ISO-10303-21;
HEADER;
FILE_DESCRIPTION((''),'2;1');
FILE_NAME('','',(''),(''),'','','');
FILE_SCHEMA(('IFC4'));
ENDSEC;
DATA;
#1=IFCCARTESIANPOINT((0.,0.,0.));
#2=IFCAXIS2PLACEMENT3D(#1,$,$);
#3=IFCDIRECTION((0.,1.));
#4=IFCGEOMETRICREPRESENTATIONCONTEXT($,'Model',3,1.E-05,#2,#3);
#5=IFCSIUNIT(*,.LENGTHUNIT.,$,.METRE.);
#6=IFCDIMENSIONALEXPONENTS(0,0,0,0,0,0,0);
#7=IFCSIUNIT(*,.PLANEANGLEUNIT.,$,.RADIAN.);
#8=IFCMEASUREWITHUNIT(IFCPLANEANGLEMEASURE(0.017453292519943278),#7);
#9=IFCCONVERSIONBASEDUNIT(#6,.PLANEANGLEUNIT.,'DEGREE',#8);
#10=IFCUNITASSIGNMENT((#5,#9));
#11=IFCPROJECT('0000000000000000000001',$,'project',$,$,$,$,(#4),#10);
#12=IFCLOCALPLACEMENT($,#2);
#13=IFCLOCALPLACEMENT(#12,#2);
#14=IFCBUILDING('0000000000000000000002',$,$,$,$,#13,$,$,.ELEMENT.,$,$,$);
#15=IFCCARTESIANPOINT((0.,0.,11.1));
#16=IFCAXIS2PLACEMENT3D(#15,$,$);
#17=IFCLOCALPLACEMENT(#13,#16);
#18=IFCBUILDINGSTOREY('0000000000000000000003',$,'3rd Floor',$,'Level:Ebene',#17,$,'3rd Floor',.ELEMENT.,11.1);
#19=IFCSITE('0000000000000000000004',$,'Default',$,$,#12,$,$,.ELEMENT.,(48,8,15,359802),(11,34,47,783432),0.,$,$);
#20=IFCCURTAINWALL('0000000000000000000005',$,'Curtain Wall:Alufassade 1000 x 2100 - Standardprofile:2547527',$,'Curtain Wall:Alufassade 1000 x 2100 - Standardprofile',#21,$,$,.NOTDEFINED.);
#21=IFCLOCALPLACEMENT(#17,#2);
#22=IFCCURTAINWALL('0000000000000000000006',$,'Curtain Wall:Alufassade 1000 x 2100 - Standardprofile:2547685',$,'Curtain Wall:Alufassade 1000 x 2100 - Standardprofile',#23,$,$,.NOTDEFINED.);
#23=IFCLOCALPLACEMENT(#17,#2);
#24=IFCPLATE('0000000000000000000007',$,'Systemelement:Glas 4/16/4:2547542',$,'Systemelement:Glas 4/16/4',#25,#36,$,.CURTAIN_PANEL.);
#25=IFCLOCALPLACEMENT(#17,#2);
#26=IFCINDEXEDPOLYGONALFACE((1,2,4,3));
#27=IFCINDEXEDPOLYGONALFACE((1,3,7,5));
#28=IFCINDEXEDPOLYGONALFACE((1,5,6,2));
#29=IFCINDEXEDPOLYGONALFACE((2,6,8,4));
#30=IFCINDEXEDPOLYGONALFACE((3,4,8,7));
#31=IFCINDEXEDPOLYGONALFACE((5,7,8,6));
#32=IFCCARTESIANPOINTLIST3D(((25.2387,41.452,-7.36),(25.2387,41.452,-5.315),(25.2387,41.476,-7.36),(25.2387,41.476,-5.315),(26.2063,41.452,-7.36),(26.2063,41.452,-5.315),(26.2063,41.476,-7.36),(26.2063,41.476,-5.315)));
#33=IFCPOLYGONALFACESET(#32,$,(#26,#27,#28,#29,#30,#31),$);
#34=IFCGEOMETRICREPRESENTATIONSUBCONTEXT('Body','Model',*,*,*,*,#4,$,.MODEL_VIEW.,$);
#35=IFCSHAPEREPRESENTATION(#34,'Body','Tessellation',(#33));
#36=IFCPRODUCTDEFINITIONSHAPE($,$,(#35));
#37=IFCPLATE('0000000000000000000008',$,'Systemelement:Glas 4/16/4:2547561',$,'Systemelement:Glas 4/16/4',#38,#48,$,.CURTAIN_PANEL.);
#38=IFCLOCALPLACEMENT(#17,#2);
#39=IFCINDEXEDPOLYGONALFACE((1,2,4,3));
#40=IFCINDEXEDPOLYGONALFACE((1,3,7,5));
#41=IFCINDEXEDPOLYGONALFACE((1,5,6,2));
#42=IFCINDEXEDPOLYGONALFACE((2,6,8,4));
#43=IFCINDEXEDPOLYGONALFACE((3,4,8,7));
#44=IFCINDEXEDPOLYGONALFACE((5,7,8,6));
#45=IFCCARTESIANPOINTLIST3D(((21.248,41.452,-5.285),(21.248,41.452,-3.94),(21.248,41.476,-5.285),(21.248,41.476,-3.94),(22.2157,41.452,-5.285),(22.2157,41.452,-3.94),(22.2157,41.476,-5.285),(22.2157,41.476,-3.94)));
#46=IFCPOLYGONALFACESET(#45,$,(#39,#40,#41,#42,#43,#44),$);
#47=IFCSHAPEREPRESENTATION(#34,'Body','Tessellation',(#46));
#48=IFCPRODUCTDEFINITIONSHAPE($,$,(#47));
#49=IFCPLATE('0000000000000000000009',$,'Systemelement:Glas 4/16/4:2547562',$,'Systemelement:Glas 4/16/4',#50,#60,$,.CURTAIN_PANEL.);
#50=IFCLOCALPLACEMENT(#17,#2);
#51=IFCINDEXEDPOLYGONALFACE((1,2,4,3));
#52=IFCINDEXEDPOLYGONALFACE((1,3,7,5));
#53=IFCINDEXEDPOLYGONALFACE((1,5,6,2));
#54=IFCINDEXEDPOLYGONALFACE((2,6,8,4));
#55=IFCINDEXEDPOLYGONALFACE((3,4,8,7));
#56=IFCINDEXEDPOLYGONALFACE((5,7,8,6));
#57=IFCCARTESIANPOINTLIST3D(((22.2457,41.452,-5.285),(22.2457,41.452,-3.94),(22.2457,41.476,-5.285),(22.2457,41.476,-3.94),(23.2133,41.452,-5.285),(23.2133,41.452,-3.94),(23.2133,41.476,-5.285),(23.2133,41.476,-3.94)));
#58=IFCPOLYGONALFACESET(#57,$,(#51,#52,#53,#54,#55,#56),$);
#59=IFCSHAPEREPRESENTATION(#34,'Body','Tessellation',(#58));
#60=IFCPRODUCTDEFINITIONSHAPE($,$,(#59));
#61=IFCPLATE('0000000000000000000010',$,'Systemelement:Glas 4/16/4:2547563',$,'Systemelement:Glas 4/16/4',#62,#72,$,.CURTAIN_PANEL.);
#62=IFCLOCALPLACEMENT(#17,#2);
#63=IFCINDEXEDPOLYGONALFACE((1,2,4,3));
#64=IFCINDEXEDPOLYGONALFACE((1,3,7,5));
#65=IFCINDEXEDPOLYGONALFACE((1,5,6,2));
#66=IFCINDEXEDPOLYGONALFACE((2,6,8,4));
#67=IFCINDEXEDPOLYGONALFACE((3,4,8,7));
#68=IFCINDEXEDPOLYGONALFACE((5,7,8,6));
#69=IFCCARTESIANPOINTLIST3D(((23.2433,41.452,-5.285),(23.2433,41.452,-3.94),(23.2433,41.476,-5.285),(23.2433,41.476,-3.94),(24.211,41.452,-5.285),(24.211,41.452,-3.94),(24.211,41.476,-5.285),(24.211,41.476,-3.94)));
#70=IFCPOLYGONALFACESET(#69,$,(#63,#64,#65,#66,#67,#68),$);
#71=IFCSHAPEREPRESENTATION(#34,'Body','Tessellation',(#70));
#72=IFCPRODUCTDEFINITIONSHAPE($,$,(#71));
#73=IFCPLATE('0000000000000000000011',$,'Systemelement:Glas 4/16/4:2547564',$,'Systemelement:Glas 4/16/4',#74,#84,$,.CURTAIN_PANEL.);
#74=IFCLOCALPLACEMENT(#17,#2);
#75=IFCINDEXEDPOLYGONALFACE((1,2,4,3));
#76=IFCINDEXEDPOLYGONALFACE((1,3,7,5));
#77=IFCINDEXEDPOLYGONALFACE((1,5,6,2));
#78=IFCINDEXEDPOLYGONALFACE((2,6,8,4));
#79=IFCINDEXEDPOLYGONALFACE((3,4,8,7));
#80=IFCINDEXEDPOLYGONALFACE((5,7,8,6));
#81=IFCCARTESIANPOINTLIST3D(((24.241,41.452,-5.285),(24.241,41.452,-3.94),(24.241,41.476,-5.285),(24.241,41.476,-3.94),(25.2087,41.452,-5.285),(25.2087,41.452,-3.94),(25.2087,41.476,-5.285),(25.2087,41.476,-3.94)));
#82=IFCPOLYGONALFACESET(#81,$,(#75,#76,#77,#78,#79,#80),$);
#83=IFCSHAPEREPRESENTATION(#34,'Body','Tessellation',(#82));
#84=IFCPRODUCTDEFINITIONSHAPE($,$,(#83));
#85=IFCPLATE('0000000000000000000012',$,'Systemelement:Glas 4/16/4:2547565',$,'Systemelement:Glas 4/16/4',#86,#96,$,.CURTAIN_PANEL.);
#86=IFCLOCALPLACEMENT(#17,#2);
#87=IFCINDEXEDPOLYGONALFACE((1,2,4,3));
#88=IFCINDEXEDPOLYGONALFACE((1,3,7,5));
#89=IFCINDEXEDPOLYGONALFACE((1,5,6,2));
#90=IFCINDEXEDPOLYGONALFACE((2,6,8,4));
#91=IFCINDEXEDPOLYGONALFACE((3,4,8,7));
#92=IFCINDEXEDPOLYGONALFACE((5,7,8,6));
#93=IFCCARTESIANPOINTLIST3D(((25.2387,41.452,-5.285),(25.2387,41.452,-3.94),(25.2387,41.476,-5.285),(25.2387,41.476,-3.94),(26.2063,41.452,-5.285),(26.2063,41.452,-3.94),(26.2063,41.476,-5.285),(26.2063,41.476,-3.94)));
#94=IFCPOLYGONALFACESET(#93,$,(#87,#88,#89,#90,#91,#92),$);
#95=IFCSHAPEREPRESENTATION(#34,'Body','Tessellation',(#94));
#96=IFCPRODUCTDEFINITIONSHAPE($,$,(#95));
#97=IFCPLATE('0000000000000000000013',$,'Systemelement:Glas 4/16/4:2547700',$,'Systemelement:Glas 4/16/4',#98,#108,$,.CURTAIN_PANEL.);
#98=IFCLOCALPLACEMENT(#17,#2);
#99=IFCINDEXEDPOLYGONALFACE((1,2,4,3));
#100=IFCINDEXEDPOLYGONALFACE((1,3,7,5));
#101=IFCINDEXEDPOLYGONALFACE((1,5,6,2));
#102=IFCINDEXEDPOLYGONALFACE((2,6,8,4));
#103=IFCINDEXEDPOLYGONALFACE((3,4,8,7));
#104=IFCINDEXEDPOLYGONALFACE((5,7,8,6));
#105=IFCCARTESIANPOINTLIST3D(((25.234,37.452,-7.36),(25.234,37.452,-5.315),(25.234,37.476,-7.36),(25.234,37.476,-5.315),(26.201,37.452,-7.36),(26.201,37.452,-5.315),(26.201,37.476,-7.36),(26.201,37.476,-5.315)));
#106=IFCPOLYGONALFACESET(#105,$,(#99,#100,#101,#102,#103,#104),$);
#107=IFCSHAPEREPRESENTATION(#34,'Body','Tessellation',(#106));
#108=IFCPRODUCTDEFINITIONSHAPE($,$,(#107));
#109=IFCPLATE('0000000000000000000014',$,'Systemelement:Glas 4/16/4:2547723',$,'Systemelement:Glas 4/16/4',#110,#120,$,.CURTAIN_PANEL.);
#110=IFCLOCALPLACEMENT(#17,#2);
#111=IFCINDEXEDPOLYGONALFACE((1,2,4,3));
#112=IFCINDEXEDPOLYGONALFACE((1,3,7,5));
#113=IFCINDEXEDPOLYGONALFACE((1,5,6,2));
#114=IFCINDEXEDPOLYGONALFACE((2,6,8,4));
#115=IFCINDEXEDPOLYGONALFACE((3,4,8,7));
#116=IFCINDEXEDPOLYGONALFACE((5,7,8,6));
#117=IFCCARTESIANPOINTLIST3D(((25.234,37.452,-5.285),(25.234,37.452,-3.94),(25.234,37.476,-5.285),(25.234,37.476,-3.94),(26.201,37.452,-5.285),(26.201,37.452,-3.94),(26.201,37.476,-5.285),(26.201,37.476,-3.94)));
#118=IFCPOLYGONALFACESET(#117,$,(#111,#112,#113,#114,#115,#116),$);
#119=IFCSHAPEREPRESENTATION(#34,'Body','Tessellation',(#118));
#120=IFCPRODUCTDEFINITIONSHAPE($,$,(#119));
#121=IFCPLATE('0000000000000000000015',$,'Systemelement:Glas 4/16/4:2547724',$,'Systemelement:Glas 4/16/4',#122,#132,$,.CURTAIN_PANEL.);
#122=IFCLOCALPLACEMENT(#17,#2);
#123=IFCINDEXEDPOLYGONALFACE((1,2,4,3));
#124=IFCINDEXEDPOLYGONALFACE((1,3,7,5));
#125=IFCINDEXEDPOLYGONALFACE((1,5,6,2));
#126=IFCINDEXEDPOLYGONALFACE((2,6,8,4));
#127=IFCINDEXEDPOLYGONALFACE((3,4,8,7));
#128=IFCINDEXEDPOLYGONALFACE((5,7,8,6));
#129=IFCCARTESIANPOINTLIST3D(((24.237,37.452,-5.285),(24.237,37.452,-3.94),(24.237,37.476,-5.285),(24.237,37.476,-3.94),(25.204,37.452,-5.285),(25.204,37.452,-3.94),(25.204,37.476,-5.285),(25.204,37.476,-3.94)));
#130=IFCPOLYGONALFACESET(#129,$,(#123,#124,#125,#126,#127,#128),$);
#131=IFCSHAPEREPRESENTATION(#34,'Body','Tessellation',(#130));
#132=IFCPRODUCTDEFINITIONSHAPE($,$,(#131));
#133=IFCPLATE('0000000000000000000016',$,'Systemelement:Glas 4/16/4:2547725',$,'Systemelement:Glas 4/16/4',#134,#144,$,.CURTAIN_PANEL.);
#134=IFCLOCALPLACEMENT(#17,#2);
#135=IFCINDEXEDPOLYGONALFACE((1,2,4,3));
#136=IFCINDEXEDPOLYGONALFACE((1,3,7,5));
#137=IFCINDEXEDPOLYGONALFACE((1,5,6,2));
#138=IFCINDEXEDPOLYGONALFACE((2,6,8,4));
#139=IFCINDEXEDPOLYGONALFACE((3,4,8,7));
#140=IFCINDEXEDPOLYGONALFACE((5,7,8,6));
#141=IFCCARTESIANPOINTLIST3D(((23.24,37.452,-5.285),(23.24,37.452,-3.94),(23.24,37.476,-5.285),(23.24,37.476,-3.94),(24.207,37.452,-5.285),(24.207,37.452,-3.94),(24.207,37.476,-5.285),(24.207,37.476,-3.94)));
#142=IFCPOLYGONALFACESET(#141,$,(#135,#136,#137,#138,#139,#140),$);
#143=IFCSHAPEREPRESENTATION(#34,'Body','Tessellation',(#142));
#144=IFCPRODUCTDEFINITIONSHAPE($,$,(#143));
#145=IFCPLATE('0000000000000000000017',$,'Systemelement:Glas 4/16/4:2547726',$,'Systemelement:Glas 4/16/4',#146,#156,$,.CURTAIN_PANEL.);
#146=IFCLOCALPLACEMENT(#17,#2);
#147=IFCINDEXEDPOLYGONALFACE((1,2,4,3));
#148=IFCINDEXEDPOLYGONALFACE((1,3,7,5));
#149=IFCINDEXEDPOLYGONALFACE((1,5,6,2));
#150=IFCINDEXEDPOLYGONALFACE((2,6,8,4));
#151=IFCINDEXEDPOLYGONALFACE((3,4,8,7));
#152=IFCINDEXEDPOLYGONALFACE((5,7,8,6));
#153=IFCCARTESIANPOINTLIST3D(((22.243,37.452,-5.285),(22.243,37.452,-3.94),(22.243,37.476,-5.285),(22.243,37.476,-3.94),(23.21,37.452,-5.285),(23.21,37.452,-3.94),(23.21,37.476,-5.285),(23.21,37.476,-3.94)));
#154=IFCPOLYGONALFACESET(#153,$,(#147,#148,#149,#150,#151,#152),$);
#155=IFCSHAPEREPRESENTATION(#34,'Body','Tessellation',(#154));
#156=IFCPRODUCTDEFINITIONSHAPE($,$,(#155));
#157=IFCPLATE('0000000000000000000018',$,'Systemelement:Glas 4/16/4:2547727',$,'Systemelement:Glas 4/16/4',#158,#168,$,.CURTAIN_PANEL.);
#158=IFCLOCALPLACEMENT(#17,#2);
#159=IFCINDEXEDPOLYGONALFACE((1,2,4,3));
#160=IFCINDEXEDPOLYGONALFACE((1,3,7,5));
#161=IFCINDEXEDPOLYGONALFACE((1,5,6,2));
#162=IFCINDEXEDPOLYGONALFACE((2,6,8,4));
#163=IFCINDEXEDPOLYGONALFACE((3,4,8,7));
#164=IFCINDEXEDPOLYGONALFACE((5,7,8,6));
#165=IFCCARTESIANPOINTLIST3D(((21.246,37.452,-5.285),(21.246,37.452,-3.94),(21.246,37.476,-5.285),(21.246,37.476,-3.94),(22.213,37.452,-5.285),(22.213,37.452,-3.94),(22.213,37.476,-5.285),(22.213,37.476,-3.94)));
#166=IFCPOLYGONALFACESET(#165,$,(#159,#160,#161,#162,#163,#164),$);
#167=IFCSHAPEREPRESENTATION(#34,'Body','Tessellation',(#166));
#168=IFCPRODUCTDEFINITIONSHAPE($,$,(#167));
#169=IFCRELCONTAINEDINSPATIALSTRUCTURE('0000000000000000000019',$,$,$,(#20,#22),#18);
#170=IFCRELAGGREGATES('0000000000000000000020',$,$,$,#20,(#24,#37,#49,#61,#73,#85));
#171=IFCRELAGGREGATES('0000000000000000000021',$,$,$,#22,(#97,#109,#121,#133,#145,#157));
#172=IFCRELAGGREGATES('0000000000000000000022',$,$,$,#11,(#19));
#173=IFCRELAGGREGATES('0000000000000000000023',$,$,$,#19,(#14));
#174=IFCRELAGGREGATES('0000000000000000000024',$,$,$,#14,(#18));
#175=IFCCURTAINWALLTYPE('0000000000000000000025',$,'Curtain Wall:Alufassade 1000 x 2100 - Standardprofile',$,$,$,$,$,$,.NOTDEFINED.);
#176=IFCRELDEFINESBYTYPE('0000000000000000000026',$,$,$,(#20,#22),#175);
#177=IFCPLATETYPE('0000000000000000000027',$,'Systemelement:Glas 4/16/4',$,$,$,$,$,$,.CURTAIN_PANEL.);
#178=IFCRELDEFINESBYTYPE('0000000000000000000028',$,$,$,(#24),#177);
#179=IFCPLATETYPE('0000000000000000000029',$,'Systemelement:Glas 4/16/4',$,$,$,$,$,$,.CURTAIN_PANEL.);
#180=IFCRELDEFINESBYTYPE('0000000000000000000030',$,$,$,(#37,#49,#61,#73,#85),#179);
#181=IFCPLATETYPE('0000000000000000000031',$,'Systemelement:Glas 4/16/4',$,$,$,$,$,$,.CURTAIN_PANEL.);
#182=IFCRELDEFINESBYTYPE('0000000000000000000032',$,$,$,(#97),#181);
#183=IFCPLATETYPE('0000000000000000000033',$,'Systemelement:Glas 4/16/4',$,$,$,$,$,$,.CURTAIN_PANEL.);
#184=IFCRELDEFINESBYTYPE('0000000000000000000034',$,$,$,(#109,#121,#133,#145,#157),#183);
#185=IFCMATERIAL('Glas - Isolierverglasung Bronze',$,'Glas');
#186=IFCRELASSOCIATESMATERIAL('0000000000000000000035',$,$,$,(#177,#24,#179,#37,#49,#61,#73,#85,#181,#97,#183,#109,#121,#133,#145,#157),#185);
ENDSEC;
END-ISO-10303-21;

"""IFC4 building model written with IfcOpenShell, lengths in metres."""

from ifc_helpers import new_model, entity, si_unit, converted_unit, direction, frame, origin, place, context, subcontext, project, spatial, indexed_curve, outline, extrude, source, transform, mapped, material, type_object, type_shapes, element, aggregate, save


model = new_model("IFC4")

# Units and contexts
model_context = context("Model", 3, precision=1e-05, world=origin(), true_north=direction((0.0, 1.0)))
body_context = subcontext(model_context, "Body", "Model", "MODEL_VIEW")
ifc_project = project(units=[si_unit("LENGTHUNIT", "METRE"), converted_unit("PLANEANGLEUNIT", "DEGREE", entity("IfcPlaneAngleMeasure", 0.017453292519943278), si_unit("PLANEANGLEUNIT", "RADIAN"), dimensions=[0, 0, 0, 0, 0, 0, 0])], contexts=[model_context])

# Site, building, storey
site_placement = place(None, origin())
site = spatial("IfcSite", under=ifc_project, at=site_placement, Name="Default", CompositionType="ELEMENT", RefLatitude=(48, 8, 15, 359802), RefLongitude=(11, 34, 47, 783432), RefElevation=0.0)
building_placement = place(site_placement, origin())
building = spatial("IfcBuilding", under=site, at=building_placement, CompositionType="ELEMENT")
storey_placement = place(building_placement, frame((0.0, 0.0, 11.1)))
storey = spatial("IfcBuildingStorey", under=building, at=storey_placement, Name="3rd Floor", ObjectType="Level:Ebene", LongName="3rd Floor", CompositionType="ELEMENT", Elevation=11.1)

# Curtain walls
curtain_wall_type = type_object("IfcCurtainWallType", Name="Curtain Wall:Alufassade 1000 x 2100 - Standardprofile", PredefinedType="NOTDEFINED")
curtain_wall_1_placement = place(storey_placement, frame((0.0, 0.0, -11.1)))
curtain_wall_1 = element("IfcCurtainWall", 1, at=curtain_wall_1_placement, inside=storey, type_object=curtain_wall_type, Name="Curtain Wall:Alufassade 1000 x 2100 - Standardprofile:2547527", ObjectType="Curtain Wall:Alufassade 1000 x 2100 - Standardprofile", PredefinedType="NOTDEFINED")
curtain_wall_2_placement = place(storey_placement, frame((0.0, 0.0, -11.1)))
curtain_wall_2 = element("IfcCurtainWall", 2, at=curtain_wall_2_placement, inside=storey, type_object=curtain_wall_type, Name="Curtain Wall:Alufassade 1000 x 2100 - Standardprofile:2547685", ObjectType="Curtain Wall:Alufassade 1000 x 2100 - Standardprofile", PredefinedType="NOTDEFINED")

# Plates
ifc_material_1 = material(Name="Glas - Isolierverglasung Bronze", Category="Glas")
plate_type_1 = type_object("IfcPlateType", Name="Systemelement:Glas 4/16/4", PredefinedType="CURTAIN_PANEL", material=ifc_material_1)
shared_shape_1 = source(origin(), body_context, "Body", "SweptSolid", [
    extrude(outline(indexed_curve([(-0.012, -0.4838), (0.012, -0.4838), (0.012, 0.4838), (-0.012, 0.4838), (-0.012, -0.4838)], self_intersect=False)), frame((0.0, 0.0, 0.0), z_axis=(0.0, 0.0, 1.0), x_axis=(0.0, 1.0, 0.0)), (0.0, 0.0, 1.0), 2.045),
])
type_shapes(plate_type_1, [shared_shape_1])
plate_1_placement = place(curtain_wall_1_placement, frame((25.7225, 41.464, 3.74)))
plate_1 = element("IfcPlate", 3, at=plate_1_placement, type_object=plate_type_1, material=ifc_material_1, Name="Systemelement:Glas 4/16/4:2547542", ObjectType="Systemelement:Glas 4/16/4", PredefinedType="CURTAIN_PANEL", context=body_context, shape_type="MappedRepresentation", body=[
    mapped(shared_shape_1, transform((0.0, 0.0, 0.0), scale=1.0)),
])
plate_type_2 = type_object("IfcPlateType", Name="Systemelement:Glas 4/16/4", PredefinedType="CURTAIN_PANEL", material=ifc_material_1)
shared_shape_2 = source(origin(), body_context, "Body", "SweptSolid", [
    extrude(outline(indexed_curve([(-0.012, -0.4838), (0.012, -0.4838), (0.012, 0.4838), (-0.012, 0.4838), (-0.012, -0.4838)], self_intersect=False)), frame((0.0, 0.0, 0.0), z_axis=(0.0, 0.0, 1.0), x_axis=(0.0, 1.0, 0.0)), (0.0, 0.0, 1.0), 1.345),
])
type_shapes(plate_type_2, [shared_shape_2])
plate_2_placement = place(curtain_wall_1_placement, frame((21.7318, 41.464, 5.815)))
plate_2 = element("IfcPlate", 4, at=plate_2_placement, type_object=plate_type_2, material=ifc_material_1, Name="Systemelement:Glas 4/16/4:2547561", ObjectType="Systemelement:Glas 4/16/4", PredefinedType="CURTAIN_PANEL", context=body_context, shape_type="MappedRepresentation", body=[
    mapped(shared_shape_2, transform((0.0, 0.0, 0.0), scale=1.0)),
])
plate_3_placement = place(curtain_wall_1_placement, frame((22.7295, 41.464, 5.815)))
plate_3 = element("IfcPlate", 5, at=plate_3_placement, type_object=plate_type_2, material=ifc_material_1, Name="Systemelement:Glas 4/16/4:2547562", ObjectType="Systemelement:Glas 4/16/4", PredefinedType="CURTAIN_PANEL", context=body_context, shape_type="MappedRepresentation", body=[
    mapped(shared_shape_2, transform((0.0, 0.0, 0.0), scale=1.0)),
])
plate_4_placement = place(curtain_wall_1_placement, frame((23.7272, 41.464, 5.815)))
plate_4 = element("IfcPlate", 6, at=plate_4_placement, type_object=plate_type_2, material=ifc_material_1, Name="Systemelement:Glas 4/16/4:2547563", ObjectType="Systemelement:Glas 4/16/4", PredefinedType="CURTAIN_PANEL", context=body_context, shape_type="MappedRepresentation", body=[
    mapped(shared_shape_2, transform((0.0, 0.0, 0.0), scale=1.0)),
])
plate_5_placement = place(curtain_wall_1_placement, frame((24.7248, 41.464, 5.815)))
plate_5 = element("IfcPlate", 7, at=plate_5_placement, type_object=plate_type_2, material=ifc_material_1, Name="Systemelement:Glas 4/16/4:2547564", ObjectType="Systemelement:Glas 4/16/4", PredefinedType="CURTAIN_PANEL", context=body_context, shape_type="MappedRepresentation", body=[
    mapped(shared_shape_2, transform((0.0, 0.0, 0.0), scale=1.0)),
])
plate_6_placement = place(curtain_wall_1_placement, frame((25.7225, 41.464, 5.815)))
plate_6 = element("IfcPlate", 8, at=plate_6_placement, type_object=plate_type_2, material=ifc_material_1, Name="Systemelement:Glas 4/16/4:2547565", ObjectType="Systemelement:Glas 4/16/4", PredefinedType="CURTAIN_PANEL", context=body_context, shape_type="MappedRepresentation", body=[
    mapped(shared_shape_2, transform((0.0, 0.0, 0.0), scale=1.0)),
])
aggregate(curtain_wall_1, [plate_1, plate_2, plate_3, plate_4, plate_5, plate_6])
plate_type_3 = type_object("IfcPlateType", Name="Systemelement:Glas 4/16/4", PredefinedType="CURTAIN_PANEL", material=ifc_material_1)
shared_shape_3 = source(origin(), body_context, "Body", "SweptSolid", [
    extrude(outline(indexed_curve([(-0.012, -0.4835), (0.012, -0.4835), (0.012, 0.4835), (-0.012, 0.4835), (-0.012, -0.4835)], self_intersect=False)), frame((0.0, 0.0, 0.0), z_axis=(0.0, 0.0, 1.0), x_axis=(0.0, 1.0, 0.0)), (0.0, 0.0, 1.0), 2.045),
])
type_shapes(plate_type_3, [shared_shape_3])
plate_7_placement = place(curtain_wall_2_placement, frame((25.7175, 37.464, 3.74), z_axis=(0.0, 0.0, 1.0), x_axis=(-1.0, 0.0, 0.0)))
plate_7 = element("IfcPlate", 9, at=plate_7_placement, type_object=plate_type_3, material=ifc_material_1, Name="Systemelement:Glas 4/16/4:2547700", ObjectType="Systemelement:Glas 4/16/4", PredefinedType="CURTAIN_PANEL", context=body_context, shape_type="MappedRepresentation", body=[
    mapped(shared_shape_3, transform((0.0, 0.0, 0.0), scale=1.0)),
])
plate_type_4 = type_object("IfcPlateType", Name="Systemelement:Glas 4/16/4", PredefinedType="CURTAIN_PANEL", material=ifc_material_1)
shared_shape_4 = source(origin(), body_context, "Body", "SweptSolid", [
    extrude(outline(indexed_curve([(-0.012, -0.4835), (0.012, -0.4835), (0.012, 0.4835), (-0.012, 0.4835), (-0.012, -0.4835)], self_intersect=False)), frame((0.0, 0.0, 0.0), z_axis=(0.0, 0.0, 1.0), x_axis=(0.0, 1.0, 0.0)), (0.0, 0.0, 1.0), 1.345),
])
type_shapes(plate_type_4, [shared_shape_4])
plate_8_placement = place(curtain_wall_2_placement, frame((25.7175, 37.464, 5.815), z_axis=(0.0, 0.0, 1.0), x_axis=(-1.0, 0.0, 0.0)))
plate_8 = element("IfcPlate", 10, at=plate_8_placement, type_object=plate_type_4, material=ifc_material_1, Name="Systemelement:Glas 4/16/4:2547723", ObjectType="Systemelement:Glas 4/16/4", PredefinedType="CURTAIN_PANEL", context=body_context, shape_type="MappedRepresentation", body=[
    mapped(shared_shape_4, transform((0.0, 0.0, 0.0), scale=1.0)),
])
plate_9_placement = place(curtain_wall_2_placement, frame((24.7205, 37.464, 5.815), z_axis=(0.0, 0.0, 1.0), x_axis=(-1.0, 0.0, 0.0)))
plate_9 = element("IfcPlate", 11, at=plate_9_placement, type_object=plate_type_4, material=ifc_material_1, Name="Systemelement:Glas 4/16/4:2547724", ObjectType="Systemelement:Glas 4/16/4", PredefinedType="CURTAIN_PANEL", context=body_context, shape_type="MappedRepresentation", body=[
    mapped(shared_shape_4, transform((0.0, 0.0, 0.0), scale=1.0)),
])
plate_10_placement = place(curtain_wall_2_placement, frame((23.7235, 37.464, 5.815), z_axis=(0.0, 0.0, 1.0), x_axis=(-1.0, 0.0, 0.0)))
plate_10 = element("IfcPlate", 12, at=plate_10_placement, type_object=plate_type_4, material=ifc_material_1, Name="Systemelement:Glas 4/16/4:2547725", ObjectType="Systemelement:Glas 4/16/4", PredefinedType="CURTAIN_PANEL", context=body_context, shape_type="MappedRepresentation", body=[
    mapped(shared_shape_4, transform((0.0, 0.0, 0.0), scale=1.0)),
])
plate_11_placement = place(curtain_wall_2_placement, frame((22.7265, 37.464, 5.815), z_axis=(0.0, 0.0, 1.0), x_axis=(-1.0, 0.0, 0.0)))
plate_11 = element("IfcPlate", 13, at=plate_11_placement, type_object=plate_type_4, material=ifc_material_1, Name="Systemelement:Glas 4/16/4:2547726", ObjectType="Systemelement:Glas 4/16/4", PredefinedType="CURTAIN_PANEL", context=body_context, shape_type="MappedRepresentation", body=[
    mapped(shared_shape_4, transform((0.0, 0.0, 0.0), scale=1.0)),
])
plate_12_placement = place(curtain_wall_2_placement, frame((21.7295, 37.464, 5.815), z_axis=(0.0, 0.0, 1.0), x_axis=(-1.0, 0.0, 0.0)))
plate_12 = element("IfcPlate", 14, at=plate_12_placement, type_object=plate_type_4, material=ifc_material_1, Name="Systemelement:Glas 4/16/4:2547727", ObjectType="Systemelement:Glas 4/16/4", PredefinedType="CURTAIN_PANEL", context=body_context, shape_type="MappedRepresentation", body=[
    mapped(shared_shape_4, transform((0.0, 0.0, 0.0), scale=1.0)),
])
aggregate(curtain_wall_2, [plate_7, plate_8, plate_9, plate_10, plate_11, plate_12])

save(model, "model.ifc")
